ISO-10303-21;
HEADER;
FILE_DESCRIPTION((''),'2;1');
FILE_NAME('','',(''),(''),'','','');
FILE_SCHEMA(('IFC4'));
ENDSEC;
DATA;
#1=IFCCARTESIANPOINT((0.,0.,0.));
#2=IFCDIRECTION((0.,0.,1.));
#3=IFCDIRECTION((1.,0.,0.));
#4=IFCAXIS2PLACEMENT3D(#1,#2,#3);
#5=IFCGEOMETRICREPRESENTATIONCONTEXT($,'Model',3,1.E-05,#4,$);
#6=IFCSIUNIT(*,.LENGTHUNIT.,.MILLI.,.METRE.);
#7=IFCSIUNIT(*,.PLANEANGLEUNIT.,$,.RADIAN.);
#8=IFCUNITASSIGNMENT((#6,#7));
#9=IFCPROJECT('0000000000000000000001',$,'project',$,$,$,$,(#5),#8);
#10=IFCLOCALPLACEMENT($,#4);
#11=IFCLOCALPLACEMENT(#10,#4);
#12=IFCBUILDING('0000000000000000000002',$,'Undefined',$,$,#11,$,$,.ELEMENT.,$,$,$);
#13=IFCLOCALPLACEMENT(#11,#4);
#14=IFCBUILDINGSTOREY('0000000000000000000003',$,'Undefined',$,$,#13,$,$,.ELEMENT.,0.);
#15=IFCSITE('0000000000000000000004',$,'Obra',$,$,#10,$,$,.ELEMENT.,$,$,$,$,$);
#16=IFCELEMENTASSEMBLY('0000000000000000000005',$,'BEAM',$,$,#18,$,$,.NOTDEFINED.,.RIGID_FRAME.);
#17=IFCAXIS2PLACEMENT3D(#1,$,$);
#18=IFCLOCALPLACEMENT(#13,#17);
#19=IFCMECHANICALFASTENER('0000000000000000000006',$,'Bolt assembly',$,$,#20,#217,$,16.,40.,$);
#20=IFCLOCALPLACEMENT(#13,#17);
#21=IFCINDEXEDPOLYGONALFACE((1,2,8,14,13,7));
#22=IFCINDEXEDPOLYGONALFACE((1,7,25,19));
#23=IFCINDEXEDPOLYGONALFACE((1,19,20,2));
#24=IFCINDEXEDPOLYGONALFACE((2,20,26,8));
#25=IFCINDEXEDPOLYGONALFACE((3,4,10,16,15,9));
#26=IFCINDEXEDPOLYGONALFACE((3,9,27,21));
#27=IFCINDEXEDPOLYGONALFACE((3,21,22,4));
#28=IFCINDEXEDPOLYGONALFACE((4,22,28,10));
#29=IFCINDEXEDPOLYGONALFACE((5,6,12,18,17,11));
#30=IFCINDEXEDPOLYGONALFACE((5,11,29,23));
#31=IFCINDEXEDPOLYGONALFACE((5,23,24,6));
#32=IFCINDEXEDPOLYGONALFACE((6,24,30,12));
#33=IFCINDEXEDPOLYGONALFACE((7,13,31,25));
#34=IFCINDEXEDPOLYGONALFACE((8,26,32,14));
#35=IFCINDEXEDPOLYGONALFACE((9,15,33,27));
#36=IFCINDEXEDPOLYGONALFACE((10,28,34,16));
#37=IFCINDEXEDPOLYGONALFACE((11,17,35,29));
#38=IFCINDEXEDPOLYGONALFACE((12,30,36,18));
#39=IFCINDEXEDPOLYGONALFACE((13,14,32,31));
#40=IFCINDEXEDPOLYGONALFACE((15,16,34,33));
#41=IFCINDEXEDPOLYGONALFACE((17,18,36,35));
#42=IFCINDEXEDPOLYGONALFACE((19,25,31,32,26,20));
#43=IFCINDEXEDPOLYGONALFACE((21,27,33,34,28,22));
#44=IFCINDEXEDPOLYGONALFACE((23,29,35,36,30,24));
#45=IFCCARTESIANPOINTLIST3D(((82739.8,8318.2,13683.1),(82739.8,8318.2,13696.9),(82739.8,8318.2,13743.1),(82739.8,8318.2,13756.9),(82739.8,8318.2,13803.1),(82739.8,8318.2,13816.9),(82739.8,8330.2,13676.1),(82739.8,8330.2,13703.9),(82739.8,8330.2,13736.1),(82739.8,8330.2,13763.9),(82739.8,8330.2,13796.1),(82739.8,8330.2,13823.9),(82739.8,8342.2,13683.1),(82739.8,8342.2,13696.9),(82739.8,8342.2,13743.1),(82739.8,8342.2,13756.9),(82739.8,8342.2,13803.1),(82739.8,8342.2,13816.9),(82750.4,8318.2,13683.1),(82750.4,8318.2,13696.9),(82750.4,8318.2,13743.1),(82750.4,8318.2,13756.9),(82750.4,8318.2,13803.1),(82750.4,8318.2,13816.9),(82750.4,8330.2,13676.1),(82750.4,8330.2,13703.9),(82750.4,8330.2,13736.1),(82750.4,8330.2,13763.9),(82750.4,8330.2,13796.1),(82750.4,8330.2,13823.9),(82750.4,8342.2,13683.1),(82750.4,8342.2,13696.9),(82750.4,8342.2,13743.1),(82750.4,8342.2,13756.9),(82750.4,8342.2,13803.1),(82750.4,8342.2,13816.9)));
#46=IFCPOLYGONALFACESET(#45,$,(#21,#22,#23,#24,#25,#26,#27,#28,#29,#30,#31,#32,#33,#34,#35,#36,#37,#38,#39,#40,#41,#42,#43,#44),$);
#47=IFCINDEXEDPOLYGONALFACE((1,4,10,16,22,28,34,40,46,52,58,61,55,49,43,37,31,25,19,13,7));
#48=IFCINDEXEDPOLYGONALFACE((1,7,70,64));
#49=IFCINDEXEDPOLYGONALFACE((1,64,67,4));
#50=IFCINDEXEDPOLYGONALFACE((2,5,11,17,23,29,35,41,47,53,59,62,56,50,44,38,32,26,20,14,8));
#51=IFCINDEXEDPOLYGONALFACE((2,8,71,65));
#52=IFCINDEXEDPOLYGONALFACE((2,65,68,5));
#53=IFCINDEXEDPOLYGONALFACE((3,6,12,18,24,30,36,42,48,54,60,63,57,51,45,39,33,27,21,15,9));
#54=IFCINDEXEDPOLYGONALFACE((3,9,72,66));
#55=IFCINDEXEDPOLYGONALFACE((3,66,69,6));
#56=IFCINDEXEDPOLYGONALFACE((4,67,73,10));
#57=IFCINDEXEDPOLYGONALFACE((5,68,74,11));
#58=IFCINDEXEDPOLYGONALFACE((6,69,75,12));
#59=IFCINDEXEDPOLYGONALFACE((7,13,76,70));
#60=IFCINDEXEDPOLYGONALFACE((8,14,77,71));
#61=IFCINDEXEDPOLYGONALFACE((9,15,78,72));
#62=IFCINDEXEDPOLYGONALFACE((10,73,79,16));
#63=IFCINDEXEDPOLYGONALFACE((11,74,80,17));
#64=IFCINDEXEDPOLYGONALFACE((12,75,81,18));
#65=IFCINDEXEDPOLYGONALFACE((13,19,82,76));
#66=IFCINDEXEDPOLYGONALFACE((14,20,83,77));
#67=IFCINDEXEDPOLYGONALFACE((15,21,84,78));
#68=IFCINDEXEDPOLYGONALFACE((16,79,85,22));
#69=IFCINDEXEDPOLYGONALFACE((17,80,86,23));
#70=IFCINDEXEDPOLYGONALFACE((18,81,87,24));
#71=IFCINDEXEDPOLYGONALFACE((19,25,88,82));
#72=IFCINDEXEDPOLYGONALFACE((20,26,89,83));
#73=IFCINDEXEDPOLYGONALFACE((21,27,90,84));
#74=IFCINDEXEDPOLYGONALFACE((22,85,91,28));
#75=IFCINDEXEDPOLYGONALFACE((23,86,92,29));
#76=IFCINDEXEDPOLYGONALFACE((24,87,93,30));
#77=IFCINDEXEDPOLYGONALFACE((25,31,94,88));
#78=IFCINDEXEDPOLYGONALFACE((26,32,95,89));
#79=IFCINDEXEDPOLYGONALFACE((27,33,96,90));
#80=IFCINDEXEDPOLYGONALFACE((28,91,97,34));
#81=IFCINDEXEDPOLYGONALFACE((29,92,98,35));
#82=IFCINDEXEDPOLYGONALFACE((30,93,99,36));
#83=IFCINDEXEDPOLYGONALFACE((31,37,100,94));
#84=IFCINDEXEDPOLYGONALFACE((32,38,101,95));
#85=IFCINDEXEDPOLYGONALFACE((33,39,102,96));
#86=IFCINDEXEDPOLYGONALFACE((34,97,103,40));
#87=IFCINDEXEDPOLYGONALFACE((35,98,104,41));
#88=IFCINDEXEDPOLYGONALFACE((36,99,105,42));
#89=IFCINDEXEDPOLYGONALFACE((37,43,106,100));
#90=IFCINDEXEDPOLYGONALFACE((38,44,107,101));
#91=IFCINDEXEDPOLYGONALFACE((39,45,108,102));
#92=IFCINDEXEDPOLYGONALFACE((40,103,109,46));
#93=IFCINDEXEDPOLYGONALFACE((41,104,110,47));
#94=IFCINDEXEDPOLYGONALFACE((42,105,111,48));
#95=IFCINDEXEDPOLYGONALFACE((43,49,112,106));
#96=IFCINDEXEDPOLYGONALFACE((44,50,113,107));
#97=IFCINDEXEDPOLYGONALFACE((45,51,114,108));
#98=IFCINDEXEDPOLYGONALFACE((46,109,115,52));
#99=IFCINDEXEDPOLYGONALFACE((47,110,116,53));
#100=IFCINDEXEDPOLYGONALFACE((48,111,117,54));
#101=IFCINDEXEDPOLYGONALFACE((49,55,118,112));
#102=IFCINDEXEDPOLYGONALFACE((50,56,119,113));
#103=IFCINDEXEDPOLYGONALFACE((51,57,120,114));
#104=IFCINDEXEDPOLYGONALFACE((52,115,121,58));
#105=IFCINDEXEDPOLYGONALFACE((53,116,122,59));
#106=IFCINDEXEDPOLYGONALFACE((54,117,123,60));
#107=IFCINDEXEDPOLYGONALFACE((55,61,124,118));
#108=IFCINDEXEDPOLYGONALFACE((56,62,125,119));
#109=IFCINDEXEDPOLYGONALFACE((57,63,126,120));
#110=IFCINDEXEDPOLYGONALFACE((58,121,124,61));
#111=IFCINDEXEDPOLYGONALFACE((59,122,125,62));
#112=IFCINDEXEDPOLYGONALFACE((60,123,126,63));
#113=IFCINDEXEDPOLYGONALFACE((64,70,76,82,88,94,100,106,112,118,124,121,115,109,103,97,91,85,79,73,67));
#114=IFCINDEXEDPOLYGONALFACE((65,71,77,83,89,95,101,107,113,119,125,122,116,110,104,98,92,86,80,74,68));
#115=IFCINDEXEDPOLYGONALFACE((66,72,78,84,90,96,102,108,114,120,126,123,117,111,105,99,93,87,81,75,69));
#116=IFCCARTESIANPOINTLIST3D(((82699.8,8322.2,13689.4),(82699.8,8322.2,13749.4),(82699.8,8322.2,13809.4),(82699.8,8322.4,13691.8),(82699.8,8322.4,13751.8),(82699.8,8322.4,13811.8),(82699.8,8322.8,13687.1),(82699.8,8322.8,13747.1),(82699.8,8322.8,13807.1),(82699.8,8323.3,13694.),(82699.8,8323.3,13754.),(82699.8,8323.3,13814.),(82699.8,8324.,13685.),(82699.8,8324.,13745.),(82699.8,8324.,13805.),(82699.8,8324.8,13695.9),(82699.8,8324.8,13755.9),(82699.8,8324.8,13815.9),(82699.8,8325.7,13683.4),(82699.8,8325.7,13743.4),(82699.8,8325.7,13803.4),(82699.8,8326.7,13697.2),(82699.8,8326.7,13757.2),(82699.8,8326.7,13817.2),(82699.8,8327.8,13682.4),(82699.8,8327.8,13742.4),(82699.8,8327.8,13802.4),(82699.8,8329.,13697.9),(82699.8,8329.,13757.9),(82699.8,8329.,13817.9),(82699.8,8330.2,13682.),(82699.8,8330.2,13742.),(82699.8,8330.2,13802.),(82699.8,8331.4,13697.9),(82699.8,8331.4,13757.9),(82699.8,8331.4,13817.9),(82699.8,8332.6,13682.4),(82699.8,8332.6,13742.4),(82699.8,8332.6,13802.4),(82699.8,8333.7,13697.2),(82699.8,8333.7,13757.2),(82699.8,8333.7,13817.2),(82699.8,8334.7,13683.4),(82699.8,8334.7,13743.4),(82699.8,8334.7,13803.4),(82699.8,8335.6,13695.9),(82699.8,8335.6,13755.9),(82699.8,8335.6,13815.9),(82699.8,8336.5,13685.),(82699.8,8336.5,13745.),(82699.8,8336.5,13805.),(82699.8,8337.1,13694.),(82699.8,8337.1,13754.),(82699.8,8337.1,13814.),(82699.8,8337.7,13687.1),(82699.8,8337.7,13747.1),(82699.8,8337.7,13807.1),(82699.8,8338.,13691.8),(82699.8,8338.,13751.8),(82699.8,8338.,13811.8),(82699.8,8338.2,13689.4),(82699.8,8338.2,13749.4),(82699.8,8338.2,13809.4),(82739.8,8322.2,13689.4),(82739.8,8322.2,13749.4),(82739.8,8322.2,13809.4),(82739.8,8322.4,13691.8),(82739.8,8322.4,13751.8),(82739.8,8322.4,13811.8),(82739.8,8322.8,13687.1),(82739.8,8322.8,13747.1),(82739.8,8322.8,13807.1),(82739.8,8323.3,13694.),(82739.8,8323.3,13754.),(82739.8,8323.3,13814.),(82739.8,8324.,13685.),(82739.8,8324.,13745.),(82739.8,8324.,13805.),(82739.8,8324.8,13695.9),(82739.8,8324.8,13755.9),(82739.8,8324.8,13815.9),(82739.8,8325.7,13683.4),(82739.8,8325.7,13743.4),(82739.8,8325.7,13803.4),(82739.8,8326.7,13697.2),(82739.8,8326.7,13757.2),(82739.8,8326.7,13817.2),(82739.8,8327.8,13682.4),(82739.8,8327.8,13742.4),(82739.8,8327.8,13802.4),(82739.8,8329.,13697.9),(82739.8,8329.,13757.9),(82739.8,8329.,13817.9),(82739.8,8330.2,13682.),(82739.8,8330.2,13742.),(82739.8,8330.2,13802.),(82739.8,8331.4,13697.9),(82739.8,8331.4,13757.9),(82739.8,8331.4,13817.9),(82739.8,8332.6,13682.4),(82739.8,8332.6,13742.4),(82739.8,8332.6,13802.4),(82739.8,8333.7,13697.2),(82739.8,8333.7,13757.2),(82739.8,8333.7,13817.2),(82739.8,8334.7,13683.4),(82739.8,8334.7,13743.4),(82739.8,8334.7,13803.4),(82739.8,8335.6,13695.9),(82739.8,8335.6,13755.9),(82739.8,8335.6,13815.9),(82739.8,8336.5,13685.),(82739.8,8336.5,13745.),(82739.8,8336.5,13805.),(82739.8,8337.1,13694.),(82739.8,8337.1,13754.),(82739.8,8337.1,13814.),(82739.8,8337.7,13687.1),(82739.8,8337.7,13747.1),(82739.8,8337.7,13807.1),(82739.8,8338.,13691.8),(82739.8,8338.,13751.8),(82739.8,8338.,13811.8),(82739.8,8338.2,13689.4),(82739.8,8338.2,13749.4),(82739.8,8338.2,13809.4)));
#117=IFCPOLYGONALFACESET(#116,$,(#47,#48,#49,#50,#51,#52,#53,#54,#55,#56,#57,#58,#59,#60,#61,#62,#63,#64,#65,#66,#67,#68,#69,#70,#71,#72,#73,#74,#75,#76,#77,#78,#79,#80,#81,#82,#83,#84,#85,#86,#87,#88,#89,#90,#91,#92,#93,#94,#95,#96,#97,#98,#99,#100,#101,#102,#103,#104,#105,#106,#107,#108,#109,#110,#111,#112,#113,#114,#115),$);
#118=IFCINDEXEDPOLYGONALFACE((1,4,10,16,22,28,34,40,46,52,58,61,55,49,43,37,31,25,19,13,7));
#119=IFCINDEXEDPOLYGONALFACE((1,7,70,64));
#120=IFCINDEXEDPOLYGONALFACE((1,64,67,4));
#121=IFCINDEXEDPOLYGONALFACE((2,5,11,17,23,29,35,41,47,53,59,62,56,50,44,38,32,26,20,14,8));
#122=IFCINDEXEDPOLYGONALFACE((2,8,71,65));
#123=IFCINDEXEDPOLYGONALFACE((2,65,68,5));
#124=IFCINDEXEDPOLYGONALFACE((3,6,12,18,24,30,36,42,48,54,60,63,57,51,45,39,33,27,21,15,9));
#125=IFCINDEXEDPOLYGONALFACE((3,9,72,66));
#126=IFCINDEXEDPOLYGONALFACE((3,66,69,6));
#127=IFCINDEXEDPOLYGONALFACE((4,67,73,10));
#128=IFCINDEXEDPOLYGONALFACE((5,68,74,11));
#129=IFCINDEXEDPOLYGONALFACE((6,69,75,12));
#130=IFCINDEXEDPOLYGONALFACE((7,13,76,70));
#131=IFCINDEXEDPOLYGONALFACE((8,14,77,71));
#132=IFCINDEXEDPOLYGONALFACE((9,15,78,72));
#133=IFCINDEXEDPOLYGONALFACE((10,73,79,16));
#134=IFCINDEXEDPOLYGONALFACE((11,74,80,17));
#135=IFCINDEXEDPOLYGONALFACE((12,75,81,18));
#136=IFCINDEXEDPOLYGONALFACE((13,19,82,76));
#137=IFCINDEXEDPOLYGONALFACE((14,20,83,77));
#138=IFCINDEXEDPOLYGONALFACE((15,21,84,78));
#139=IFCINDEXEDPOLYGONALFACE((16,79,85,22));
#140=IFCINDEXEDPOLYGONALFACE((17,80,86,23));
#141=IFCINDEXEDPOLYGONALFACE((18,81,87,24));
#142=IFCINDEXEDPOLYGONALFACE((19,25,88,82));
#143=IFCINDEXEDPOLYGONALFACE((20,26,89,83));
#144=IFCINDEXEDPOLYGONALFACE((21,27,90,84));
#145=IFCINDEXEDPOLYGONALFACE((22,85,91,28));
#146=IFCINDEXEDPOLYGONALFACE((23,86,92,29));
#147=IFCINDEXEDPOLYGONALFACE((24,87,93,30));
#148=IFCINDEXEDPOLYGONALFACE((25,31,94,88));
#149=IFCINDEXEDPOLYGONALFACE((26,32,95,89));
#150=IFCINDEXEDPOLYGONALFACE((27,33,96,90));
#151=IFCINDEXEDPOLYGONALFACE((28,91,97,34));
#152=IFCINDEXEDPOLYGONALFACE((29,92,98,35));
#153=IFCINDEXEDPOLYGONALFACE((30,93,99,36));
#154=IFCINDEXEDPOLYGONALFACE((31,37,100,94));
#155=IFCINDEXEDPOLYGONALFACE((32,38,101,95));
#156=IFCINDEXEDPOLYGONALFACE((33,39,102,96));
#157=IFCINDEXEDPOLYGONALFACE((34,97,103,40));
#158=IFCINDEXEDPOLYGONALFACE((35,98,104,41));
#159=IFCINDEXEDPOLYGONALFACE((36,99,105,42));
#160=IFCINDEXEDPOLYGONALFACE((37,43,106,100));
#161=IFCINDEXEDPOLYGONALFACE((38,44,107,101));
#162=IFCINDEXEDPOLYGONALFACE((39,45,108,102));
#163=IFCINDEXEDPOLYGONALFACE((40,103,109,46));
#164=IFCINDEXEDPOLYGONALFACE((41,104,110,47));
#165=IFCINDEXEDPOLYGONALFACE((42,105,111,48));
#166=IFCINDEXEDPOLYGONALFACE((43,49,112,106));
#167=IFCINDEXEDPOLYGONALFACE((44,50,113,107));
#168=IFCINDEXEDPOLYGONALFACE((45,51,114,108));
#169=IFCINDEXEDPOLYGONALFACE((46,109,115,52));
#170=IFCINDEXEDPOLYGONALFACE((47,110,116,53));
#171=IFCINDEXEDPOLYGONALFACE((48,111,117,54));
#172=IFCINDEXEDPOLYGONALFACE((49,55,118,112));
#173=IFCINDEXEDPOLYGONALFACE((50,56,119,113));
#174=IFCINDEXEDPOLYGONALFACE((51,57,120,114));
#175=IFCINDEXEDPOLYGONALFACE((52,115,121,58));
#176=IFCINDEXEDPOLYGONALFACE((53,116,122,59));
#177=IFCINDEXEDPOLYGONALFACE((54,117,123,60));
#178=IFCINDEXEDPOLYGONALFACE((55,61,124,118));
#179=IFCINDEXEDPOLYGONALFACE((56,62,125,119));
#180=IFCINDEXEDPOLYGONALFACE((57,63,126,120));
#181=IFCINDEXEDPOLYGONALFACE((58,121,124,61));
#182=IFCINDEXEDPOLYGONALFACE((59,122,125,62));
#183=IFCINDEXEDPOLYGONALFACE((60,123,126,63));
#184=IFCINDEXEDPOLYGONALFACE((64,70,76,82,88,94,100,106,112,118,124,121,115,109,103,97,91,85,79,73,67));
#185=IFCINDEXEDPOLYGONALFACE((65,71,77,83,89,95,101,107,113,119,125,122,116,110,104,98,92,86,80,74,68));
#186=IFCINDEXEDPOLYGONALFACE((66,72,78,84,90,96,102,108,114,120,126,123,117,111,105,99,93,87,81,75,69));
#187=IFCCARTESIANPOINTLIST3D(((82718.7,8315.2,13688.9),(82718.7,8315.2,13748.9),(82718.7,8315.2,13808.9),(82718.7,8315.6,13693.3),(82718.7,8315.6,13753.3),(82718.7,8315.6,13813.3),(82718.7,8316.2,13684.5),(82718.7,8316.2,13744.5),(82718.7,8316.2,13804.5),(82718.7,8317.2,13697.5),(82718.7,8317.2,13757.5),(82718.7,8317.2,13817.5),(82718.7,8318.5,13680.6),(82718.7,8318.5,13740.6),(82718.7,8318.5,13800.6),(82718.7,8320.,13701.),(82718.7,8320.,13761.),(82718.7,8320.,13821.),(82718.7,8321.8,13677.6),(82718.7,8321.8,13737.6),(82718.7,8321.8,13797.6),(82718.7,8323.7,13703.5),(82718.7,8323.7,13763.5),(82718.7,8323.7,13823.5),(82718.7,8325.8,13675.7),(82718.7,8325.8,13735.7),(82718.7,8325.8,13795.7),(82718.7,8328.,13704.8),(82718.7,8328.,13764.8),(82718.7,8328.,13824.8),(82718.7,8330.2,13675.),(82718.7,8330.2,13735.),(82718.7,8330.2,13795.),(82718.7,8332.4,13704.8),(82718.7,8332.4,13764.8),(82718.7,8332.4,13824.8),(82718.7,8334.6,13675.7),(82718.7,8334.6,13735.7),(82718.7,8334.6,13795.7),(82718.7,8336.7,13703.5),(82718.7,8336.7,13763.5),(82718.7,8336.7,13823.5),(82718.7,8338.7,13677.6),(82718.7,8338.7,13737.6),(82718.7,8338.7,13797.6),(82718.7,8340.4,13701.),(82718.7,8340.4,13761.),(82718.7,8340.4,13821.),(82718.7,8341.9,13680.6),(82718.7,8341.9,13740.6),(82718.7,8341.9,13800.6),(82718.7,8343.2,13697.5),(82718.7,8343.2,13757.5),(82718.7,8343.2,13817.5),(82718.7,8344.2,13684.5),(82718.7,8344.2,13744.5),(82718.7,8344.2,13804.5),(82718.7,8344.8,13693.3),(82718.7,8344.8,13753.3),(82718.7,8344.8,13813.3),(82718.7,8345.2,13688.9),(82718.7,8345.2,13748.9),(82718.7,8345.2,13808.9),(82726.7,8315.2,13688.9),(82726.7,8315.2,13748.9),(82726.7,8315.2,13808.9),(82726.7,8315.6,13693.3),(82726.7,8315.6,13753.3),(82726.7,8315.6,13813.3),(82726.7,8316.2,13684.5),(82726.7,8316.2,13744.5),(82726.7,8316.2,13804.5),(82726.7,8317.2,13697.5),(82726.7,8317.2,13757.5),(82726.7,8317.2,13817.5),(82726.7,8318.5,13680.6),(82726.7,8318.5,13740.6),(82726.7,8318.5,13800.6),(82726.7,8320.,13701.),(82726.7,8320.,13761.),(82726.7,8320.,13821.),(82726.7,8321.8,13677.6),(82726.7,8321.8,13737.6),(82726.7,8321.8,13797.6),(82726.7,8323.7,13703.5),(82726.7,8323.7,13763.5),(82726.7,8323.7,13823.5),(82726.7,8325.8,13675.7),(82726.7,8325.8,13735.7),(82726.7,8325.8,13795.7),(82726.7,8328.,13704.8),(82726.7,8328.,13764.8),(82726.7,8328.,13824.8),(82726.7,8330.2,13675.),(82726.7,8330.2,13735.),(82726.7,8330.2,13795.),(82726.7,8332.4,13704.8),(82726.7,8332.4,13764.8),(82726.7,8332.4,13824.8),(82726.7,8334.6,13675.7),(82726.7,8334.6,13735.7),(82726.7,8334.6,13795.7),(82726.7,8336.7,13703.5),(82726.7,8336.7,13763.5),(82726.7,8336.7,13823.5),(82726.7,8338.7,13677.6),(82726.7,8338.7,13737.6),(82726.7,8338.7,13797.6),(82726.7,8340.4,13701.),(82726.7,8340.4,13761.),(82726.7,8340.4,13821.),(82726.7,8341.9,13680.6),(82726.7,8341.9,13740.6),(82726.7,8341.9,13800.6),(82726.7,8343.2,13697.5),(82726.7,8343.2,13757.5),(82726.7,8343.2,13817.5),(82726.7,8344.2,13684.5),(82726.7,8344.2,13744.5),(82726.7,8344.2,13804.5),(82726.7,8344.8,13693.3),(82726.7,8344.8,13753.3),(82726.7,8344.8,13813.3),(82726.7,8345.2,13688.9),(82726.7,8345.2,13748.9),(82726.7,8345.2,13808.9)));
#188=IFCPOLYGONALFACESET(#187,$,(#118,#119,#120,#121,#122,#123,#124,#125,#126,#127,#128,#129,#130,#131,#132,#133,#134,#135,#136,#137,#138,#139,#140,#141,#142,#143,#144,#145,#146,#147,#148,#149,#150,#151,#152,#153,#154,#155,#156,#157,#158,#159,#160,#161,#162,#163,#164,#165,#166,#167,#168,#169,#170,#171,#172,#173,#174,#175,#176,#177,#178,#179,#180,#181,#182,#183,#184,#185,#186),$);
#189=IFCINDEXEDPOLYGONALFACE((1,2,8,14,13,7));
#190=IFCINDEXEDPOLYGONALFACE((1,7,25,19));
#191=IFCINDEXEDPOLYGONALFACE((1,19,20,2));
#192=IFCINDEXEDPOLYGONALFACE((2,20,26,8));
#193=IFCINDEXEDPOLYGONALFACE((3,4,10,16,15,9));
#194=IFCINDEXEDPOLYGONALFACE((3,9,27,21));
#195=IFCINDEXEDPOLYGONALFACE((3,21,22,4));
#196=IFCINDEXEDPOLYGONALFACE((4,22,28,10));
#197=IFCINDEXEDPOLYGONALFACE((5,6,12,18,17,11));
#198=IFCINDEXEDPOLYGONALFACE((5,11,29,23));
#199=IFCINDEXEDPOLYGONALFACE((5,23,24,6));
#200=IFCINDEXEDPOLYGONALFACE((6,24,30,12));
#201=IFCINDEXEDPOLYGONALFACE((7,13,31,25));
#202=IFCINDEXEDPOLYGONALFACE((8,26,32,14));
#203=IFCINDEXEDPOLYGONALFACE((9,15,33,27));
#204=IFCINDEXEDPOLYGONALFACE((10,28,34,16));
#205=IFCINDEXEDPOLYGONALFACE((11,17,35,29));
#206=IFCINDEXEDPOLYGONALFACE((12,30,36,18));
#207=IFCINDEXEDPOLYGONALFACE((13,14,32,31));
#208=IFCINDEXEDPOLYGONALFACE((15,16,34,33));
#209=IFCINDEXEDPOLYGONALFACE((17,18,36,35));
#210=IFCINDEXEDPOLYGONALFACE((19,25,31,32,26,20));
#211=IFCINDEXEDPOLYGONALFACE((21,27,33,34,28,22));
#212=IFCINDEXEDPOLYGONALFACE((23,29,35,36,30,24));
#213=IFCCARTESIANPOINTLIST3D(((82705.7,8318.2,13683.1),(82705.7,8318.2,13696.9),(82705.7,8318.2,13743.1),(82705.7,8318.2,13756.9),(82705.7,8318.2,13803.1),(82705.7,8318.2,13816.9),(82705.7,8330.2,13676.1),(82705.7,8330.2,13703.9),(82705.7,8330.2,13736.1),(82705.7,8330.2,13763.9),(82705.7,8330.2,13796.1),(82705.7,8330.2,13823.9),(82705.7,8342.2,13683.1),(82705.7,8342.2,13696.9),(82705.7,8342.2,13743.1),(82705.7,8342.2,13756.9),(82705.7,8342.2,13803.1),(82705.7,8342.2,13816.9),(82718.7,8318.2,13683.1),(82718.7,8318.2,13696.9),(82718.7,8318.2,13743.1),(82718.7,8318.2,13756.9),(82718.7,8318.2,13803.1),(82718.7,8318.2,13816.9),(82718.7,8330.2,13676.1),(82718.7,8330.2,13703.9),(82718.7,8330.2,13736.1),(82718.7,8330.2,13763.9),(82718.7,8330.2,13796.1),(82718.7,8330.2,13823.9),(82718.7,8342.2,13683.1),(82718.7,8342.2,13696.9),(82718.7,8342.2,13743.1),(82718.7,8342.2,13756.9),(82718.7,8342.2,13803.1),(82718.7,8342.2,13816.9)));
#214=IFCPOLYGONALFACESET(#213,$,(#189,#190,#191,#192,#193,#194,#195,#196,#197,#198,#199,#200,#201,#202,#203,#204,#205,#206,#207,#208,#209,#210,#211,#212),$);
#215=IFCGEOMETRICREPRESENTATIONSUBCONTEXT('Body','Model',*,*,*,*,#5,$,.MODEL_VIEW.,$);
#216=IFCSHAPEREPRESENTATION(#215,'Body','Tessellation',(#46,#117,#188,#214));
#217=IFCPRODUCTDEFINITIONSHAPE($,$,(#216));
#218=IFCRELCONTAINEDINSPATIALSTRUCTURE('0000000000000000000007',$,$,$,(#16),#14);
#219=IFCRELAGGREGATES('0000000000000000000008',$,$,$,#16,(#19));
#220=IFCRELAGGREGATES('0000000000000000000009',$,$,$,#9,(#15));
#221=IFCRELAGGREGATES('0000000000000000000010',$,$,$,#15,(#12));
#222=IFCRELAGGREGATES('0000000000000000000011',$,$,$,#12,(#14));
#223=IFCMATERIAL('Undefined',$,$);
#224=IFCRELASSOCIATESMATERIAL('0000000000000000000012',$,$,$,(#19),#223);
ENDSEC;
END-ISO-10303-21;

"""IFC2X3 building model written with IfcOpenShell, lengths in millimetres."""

from ifc_helpers import new_model, si_unit, frame, origin_with_axes, origin_2d_with_axis, place, context, subcontext, project, spatial, polyline, circle, outline, extrude, source, transform, mapped, material, element, aggregate, save


model = new_model("IFC2X3")

# Units and contexts
model_context = context("Model", 3, precision=1e-05, world=origin_with_axes())
body_context = subcontext(model_context, "Body", "Model", "MODEL_VIEW")
ifc_project = project(units=[si_unit("LENGTHUNIT", "METRE", prefix="MILLI"), si_unit("PLANEANGLEUNIT", "RADIAN")], contexts=[model_context])

# Site, building, storey
site_placement = place(None, origin_with_axes())
site = spatial("IfcSite", under=ifc_project, at=site_placement, Name="Obra", CompositionType="ELEMENT")
building_placement = place(site_placement, origin_with_axes())
building = spatial("IfcBuilding", under=site, at=building_placement, Name="Undefined", CompositionType="ELEMENT")
storey_placement = place(building_placement, origin_with_axes())
storey = spatial("IfcBuildingStorey", under=building, at=storey_placement, Name="Undefined", CompositionType="ELEMENT", Elevation=0.0)

# Element assembly
assembly_1_placement = place(storey_placement, origin_with_axes())
assembly_1 = element("IfcElementAssembly", 1, at=assembly_1_placement, inside=storey, Name="BEAM", AssemblyPlace="NOTDEFINED", PredefinedType="RIGID_FRAME")

# Shared definitions
ifc_material_1 = material(Name="Undefined")

# Mechanical fastener
shared_shape_1 = source(origin_with_axes(), body_context, "Body", "SweptSolid", [
    extrude(outline(polyline([(13.9, 0.0), (6.9, 12.0), (-6.9, 12.0), (-13.9, 0.0), (-6.9, -12.0), (6.9, -12.0), (13.9, 0.0)])), frame((0.0, -20.1, 0.0), z_axis=(0.0, 1.0, 0.0), x_axis=(1.0, 0.0, 0.0)), (0.0, 0.0, 1.0), 10.6),
    extrude(circle(Radius=8.0, at=origin_2d_with_axis()), frame((0.0, -9.5, 0.0), z_axis=(0.0, 1.0, 0.0), x_axis=(1.0, 0.0, 0.0)), (0.0, 0.0, 1.0), 40.0),
    extrude(circle(Radius=15.0, at=origin_2d_with_axis()), frame((0.0, 3.5, 0.0), z_axis=(0.0, 1.0, 0.0), x_axis=(1.0, 0.0, 0.0)), (0.0, 0.0, 1.0), 8.0),
    extrude(outline(polyline([(13.9, 0.0), (6.9, 12.0), (-6.9, 12.0), (-13.9, 0.0), (-6.9, -12.0), (6.9, -12.0), (13.9, 0.0)])), frame((0.0, 11.5, 0.0), z_axis=(0.0, 1.0, 0.0), x_axis=(1.0, 0.0, 0.0)), (0.0, 0.0, 1.0), 13.0),
])
mechanical_fastener_1_placement = place(assembly_1_placement, frame((82730.3, 8280.2, 13845.0), z_axis=(0.0, 1.0, 0.0), x_axis=(0.0, 0.0, -1.0)))
mechanical_fastener_1 = element("IfcMechanicalFastener", 2, at=mechanical_fastener_1_placement, material=ifc_material_1, Name="Bolt assembly", NominalDiameter=16.0, NominalLength=40.0, context=body_context, shape_type="MappedRepresentation", body=[
    mapped(shared_shape_1, transform((35.0, 0.0, 50.0))),
    mapped(shared_shape_1, transform((95.0, 0.0, 50.0))),
    mapped(shared_shape_1, transform((155.0, 0.0, 50.0))),
])
aggregate(assembly_1, [mechanical_fastener_1])

save(model, "model.ifc")
